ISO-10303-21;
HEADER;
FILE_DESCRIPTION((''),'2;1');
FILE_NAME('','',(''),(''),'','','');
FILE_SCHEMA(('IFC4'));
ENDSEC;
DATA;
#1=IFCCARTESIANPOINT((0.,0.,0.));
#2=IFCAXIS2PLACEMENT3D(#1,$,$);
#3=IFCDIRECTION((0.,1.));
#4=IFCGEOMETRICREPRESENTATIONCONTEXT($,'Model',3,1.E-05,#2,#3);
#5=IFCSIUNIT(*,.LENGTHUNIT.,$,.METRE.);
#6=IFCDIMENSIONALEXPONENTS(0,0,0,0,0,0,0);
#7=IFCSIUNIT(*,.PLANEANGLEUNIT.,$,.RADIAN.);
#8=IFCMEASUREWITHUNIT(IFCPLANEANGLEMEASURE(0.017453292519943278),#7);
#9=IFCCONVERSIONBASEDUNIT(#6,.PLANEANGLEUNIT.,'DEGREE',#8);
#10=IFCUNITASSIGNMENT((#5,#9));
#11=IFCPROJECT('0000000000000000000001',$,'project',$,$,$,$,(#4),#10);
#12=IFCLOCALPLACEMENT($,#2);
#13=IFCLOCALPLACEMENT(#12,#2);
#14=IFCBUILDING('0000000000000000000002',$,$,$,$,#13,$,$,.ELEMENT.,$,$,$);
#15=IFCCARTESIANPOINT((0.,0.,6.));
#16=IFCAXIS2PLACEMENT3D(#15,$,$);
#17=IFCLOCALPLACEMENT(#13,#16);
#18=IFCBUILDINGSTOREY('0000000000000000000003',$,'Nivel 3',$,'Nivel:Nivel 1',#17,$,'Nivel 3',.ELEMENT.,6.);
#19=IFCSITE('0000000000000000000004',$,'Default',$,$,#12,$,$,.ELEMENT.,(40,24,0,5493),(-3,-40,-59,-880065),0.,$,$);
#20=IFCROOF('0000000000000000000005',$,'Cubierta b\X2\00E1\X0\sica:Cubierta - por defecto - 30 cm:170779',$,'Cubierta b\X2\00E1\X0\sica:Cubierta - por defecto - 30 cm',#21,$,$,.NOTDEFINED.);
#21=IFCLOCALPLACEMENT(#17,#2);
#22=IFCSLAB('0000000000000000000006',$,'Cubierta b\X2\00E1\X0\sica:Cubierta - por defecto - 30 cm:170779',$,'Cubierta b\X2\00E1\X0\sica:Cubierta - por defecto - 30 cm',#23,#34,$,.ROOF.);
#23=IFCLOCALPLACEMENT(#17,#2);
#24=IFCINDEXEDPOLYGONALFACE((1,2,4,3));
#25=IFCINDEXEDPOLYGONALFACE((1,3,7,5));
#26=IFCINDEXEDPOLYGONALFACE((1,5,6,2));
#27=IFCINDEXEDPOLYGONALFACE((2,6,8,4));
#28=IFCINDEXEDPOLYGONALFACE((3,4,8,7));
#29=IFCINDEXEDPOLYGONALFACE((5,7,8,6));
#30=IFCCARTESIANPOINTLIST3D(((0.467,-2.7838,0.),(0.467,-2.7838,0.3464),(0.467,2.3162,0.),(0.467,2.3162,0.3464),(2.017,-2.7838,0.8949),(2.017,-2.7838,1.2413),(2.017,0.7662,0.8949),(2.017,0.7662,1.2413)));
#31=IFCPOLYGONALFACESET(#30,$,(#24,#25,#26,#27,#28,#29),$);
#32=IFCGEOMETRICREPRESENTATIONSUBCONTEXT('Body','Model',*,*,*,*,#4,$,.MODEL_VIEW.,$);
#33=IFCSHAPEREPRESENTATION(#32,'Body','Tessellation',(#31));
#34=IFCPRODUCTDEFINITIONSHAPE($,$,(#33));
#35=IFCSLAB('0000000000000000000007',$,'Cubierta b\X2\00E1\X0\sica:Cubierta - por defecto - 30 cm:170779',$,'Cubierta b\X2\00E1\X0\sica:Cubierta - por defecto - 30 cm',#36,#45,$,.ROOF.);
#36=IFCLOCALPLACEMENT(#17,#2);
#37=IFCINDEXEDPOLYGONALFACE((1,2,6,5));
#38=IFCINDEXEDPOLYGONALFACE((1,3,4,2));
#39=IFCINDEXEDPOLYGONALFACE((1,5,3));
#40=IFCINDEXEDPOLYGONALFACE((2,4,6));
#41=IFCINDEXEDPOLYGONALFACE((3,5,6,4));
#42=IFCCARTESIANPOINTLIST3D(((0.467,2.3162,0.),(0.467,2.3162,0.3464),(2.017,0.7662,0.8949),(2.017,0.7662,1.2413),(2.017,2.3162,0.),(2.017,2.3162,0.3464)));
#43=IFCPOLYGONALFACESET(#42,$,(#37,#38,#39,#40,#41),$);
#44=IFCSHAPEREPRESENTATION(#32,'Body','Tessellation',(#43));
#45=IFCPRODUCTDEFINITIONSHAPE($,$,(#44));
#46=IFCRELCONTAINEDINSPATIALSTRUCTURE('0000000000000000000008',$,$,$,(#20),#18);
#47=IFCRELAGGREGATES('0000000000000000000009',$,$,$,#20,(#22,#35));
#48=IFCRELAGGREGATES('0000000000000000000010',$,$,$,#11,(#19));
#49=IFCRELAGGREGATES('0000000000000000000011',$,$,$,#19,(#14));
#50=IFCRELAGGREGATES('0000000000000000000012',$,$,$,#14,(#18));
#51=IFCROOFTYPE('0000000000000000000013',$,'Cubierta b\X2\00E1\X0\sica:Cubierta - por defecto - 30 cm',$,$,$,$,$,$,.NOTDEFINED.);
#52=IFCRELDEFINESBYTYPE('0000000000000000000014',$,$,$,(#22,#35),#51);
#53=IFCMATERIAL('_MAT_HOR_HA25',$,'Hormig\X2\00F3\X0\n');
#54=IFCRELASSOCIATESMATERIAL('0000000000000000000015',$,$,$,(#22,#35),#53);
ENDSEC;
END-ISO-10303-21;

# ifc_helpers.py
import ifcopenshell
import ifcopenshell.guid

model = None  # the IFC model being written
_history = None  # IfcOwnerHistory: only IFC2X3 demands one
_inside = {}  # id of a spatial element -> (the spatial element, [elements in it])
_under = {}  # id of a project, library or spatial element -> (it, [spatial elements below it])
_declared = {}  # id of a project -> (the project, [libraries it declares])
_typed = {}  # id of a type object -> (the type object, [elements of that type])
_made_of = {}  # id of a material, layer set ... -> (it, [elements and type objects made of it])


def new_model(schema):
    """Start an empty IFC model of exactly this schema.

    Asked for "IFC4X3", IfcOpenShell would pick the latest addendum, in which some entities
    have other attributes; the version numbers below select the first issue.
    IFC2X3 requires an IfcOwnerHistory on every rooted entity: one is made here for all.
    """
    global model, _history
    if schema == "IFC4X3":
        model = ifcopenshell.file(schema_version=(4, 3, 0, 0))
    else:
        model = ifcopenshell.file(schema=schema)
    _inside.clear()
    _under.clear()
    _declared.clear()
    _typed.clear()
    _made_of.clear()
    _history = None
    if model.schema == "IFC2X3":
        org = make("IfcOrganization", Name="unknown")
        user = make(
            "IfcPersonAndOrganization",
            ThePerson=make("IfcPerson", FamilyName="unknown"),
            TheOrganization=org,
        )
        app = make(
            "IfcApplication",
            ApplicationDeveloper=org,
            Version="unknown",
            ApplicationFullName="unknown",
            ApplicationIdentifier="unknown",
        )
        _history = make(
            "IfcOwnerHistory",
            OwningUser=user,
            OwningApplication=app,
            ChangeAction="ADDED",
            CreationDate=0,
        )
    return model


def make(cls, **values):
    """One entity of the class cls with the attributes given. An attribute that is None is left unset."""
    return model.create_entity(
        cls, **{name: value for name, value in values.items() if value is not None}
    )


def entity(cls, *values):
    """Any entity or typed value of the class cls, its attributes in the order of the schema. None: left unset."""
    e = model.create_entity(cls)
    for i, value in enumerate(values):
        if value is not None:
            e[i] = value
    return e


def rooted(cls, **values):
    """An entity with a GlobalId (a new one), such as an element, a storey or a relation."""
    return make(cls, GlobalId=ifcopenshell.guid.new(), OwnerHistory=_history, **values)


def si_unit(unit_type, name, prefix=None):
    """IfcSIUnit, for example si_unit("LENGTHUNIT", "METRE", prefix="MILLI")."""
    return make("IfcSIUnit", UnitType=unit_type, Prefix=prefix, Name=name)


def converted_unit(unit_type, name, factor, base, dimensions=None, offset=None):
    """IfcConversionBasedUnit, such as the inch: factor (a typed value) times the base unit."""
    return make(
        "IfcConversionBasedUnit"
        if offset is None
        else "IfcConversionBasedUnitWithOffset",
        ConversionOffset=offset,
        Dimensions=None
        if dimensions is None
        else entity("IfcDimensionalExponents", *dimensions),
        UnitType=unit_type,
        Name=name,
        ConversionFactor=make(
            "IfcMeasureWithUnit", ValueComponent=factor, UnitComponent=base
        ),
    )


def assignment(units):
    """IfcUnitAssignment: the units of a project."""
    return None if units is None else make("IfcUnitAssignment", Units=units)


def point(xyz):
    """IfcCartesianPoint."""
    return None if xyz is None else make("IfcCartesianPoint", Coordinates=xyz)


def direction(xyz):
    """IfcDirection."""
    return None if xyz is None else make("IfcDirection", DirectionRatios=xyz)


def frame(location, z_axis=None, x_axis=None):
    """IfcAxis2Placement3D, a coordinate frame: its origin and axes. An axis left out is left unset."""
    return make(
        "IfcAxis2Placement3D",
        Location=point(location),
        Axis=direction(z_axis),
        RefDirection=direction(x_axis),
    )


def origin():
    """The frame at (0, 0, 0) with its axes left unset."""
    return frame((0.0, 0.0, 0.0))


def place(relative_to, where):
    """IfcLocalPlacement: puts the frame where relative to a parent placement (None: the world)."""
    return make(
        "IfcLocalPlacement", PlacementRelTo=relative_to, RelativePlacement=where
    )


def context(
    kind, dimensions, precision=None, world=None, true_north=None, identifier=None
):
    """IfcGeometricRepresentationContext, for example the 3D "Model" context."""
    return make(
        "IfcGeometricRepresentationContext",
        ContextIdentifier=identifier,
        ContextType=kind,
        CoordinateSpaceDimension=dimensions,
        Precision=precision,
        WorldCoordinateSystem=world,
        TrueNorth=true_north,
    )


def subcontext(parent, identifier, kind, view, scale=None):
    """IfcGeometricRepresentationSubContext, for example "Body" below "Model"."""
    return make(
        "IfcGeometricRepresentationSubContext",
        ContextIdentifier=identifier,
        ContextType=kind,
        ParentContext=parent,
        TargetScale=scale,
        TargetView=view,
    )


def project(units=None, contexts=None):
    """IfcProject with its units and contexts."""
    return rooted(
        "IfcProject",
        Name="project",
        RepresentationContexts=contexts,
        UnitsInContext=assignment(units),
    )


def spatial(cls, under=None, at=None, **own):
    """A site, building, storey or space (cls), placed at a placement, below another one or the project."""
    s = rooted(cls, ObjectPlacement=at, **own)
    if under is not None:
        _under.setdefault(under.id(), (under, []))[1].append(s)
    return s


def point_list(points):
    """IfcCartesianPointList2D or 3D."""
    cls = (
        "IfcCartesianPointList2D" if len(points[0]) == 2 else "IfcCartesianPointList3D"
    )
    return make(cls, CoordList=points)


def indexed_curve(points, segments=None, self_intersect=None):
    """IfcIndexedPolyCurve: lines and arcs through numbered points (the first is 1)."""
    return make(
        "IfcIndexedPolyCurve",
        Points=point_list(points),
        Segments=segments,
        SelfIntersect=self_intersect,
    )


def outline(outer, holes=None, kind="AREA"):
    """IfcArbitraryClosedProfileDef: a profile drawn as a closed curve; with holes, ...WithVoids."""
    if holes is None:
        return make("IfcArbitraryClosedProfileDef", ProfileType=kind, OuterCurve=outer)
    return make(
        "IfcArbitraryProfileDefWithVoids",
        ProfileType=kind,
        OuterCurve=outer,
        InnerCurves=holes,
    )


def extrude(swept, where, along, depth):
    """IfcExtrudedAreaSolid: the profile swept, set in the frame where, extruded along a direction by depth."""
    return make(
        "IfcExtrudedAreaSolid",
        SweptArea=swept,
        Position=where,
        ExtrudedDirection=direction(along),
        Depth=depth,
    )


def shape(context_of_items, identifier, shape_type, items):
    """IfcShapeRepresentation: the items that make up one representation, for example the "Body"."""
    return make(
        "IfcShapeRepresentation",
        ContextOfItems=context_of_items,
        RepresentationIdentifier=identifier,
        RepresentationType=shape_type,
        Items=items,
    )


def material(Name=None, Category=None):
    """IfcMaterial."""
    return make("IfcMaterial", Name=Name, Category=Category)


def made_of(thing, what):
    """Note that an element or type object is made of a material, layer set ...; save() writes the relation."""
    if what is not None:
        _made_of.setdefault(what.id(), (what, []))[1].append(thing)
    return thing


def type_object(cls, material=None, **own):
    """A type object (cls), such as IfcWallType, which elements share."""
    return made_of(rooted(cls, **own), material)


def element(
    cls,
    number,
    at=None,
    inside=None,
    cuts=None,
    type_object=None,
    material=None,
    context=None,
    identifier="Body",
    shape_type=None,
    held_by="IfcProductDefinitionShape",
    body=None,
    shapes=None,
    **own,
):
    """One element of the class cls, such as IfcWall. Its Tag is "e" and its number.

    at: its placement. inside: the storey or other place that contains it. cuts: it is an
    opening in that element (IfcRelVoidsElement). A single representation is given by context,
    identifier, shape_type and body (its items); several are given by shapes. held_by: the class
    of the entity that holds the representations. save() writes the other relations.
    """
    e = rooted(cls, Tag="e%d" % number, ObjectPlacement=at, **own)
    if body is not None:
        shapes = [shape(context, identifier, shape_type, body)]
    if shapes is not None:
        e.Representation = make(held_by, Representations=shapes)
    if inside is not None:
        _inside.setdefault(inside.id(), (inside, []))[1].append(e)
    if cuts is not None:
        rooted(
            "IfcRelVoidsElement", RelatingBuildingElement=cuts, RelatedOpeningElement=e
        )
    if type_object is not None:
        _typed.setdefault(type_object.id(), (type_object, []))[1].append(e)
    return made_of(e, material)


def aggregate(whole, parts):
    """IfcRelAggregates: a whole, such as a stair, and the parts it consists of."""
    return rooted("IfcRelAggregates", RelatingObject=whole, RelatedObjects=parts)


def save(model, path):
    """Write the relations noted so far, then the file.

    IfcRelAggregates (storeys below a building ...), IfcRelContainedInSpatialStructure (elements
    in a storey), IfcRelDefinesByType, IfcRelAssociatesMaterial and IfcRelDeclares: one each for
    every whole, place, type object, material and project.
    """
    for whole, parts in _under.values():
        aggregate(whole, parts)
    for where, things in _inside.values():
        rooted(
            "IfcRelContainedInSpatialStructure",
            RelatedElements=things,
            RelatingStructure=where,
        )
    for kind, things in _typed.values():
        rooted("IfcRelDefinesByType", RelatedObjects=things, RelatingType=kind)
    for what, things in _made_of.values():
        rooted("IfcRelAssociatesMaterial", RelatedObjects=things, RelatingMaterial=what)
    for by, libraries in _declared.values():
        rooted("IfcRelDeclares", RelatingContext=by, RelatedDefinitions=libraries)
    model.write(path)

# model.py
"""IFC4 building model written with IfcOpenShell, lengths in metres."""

from ifc_helpers import new_model, entity, si_unit, converted_unit, direction, frame, origin, place, context, subcontext, project, spatial, indexed_curve, outline, extrude, material, type_object, element, aggregate, save


model = new_model("IFC4")

# Units and contexts
model_context = context("Model", 3, precision=1e-05, world=origin(), true_north=direction((0.0, 1.0)))
body_context = subcontext(model_context, "Body", "Model", "MODEL_VIEW")
ifc_project = project(units=[si_unit("LENGTHUNIT", "METRE"), converted_unit("PLANEANGLEUNIT", "DEGREE", entity("IfcPlaneAngleMeasure", 0.017453292519943278), si_unit("PLANEANGLEUNIT", "RADIAN"), dimensions=[0, 0, 0, 0, 0, 0, 0])], contexts=[model_context])

# Site, building, storey
site_placement = place(None, origin())
site = spatial("IfcSite", under=ifc_project, at=site_placement, Name="Default", CompositionType="ELEMENT", RefLatitude=(40, 24, 0, 5493), RefLongitude=(-3, -40, -59, -880065), RefElevation=0.0)
building_placement = place(site_placement, origin())
building = spatial("IfcBuilding", under=site, at=building_placement, CompositionType="ELEMENT")
storey_placement = place(building_placement, frame((0.0, 0.0, 6.0)))
storey = spatial("IfcBuildingStorey", under=building, at=storey_placement, Name="Nivel 3", ObjectType="Nivel:Nivel 1", LongName="Nivel 3", CompositionType="ELEMENT", Elevation=6.0)

# Roof, slabs
roof_placement = place(storey_placement, frame((0.467, -2.7838, 0.0)))
roof = element("IfcRoof", 1, at=roof_placement, inside=storey, Name="Cubierta básica:Cubierta - por defecto - 30 cm:170779", ObjectType="Cubierta básica:Cubierta - por defecto - 30 cm", PredefinedType="NOTDEFINED")
ifc_material = material(Name="_MAT_HOR_HA25", Category="Hormigón")
roof_type = type_object("IfcRoofType", Name="Cubierta básica:Cubierta - por defecto - 30 cm", PredefinedType="NOTDEFINED")
slab_1_placement = place(roof_placement, origin())
slab_1 = element("IfcSlab", 2, at=slab_1_placement, type_object=roof_type, material=ifc_material, Name="Cubierta básica:Cubierta - por defecto - 30 cm:170779", ObjectType="Cubierta básica:Cubierta - por defecto - 30 cm", PredefinedType="ROOF", context=body_context, shape_type="SweptSolid", body=[
    extrude(outline(indexed_curve([(0.8949, 1.0), (-0.8949, 2.55), (-0.8949, -2.55), (0.8949, -2.55), (0.8949, 1.0)], self_intersect=False)), frame((0.775, 2.55, 0.4474), z_axis=(-0.5, 0.0, 0.866025), x_axis=(0.866025, 0.0, 0.5)), (0.5, 0.0, 0.866025), 0.3464),
])
slab_2_placement = place(roof_placement, origin())
slab_2 = element("IfcSlab", 3, at=slab_2_placement, type_object=roof_type, material=ifc_material, Name="Cubierta básica:Cubierta - por defecto - 30 cm:170779", ObjectType="Cubierta básica:Cubierta - por defecto - 30 cm", PredefinedType="ROOF", context=body_context, shape_type="SweptSolid", body=[
    extrude(outline(indexed_curve([(-0.775, 0.8949), (0.775, -0.8949), (0.775, 0.8949), (-0.775, 0.8949)], self_intersect=False)), frame((0.775, 4.325, 0.4474), z_axis=(0.0, 0.5, 0.866025), x_axis=(1.0, 0.0, 0.0)), (0.0, -0.5, 0.866025), 0.3464),
])
aggregate(roof, [slab_1, slab_2])

save(model, "model.ifc")
